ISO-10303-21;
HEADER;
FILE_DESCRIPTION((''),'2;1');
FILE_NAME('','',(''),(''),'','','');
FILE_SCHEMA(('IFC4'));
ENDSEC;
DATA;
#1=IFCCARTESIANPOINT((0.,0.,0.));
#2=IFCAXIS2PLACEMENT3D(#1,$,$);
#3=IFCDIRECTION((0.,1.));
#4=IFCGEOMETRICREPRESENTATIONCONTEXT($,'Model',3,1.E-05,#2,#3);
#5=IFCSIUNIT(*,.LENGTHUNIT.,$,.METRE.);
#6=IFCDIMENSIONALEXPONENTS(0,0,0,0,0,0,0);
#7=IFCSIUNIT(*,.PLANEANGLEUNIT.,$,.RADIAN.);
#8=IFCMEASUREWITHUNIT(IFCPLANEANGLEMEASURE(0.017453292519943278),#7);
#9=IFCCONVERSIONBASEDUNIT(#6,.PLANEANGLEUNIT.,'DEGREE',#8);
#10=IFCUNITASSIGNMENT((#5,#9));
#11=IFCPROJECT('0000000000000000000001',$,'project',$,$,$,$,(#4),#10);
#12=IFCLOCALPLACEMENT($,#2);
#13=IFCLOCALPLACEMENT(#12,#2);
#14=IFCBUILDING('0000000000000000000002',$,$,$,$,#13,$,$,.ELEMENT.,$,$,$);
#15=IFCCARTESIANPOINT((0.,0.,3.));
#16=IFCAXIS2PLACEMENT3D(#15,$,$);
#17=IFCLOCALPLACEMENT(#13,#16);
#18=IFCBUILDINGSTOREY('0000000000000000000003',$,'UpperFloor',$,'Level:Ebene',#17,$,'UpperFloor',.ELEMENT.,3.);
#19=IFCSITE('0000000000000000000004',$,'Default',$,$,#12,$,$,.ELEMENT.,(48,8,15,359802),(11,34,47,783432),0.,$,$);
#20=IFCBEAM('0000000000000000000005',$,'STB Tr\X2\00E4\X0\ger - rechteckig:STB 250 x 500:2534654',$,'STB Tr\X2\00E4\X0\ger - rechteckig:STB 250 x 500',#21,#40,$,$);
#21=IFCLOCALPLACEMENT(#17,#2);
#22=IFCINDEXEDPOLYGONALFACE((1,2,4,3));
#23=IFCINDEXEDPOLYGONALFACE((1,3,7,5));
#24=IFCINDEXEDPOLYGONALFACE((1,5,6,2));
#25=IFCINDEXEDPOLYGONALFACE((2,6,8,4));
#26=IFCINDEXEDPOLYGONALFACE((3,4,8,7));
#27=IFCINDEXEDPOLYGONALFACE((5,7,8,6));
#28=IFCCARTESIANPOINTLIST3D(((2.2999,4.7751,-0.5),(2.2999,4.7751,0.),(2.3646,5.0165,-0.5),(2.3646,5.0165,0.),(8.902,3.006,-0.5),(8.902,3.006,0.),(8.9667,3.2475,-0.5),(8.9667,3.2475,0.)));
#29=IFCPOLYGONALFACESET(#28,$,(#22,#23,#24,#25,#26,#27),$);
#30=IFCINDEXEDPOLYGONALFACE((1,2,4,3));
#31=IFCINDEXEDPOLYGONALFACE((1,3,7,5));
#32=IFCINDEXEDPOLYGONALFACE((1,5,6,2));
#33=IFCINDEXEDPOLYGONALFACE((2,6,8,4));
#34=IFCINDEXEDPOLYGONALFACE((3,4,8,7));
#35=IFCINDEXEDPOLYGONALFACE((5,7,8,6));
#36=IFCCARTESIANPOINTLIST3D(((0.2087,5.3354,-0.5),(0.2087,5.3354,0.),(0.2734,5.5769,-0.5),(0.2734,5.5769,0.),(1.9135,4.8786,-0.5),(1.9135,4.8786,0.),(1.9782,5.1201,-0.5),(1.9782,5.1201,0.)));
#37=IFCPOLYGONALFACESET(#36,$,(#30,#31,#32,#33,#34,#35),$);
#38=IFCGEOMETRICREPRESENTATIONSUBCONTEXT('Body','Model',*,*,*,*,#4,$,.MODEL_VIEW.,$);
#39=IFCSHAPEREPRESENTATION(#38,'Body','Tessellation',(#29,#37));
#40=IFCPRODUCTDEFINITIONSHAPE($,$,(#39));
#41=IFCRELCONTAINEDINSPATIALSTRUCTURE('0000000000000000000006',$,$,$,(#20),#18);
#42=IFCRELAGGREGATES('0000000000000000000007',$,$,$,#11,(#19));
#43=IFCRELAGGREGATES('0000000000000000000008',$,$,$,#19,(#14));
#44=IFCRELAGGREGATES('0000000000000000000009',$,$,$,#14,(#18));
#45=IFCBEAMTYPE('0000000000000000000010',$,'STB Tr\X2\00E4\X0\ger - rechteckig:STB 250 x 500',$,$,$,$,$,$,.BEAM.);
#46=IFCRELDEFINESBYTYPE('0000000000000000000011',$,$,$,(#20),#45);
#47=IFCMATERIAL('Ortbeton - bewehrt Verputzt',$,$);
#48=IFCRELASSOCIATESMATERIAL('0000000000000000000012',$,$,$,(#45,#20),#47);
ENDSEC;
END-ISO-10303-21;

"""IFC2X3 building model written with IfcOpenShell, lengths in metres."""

from ifc_helpers import new_model, entity, si_unit, converted_unit, direction, frame, frame_2d, origin, origin_2d_with_axis, place, context, subcontext, project, spatial, rectangle, extrude, source, transform, mapped, material, type_object, type_shapes, element, save


model = new_model("IFC2X3")

# Units and contexts
model_context = context("Model", 3, precision=1e-05, world=origin(), true_north=direction((0.0, 1.0)))
body_context = subcontext(model_context, "Body", "Model", "MODEL_VIEW")
ifc_project = project(units=[si_unit("LENGTHUNIT", "METRE"), converted_unit("PLANEANGLEUNIT", "DEGREE", entity("IfcPlaneAngleMeasure", 0.017453292519943278), si_unit("PLANEANGLEUNIT", "RADIAN"), dimensions=[0, 0, 0, 0, 0, 0, 0])], contexts=[model_context])

# Site, building, storey
site_placement = place(None, origin())
site = spatial("IfcSite", under=ifc_project, at=site_placement, Name="Default", CompositionType="ELEMENT", RefLatitude=(48, 8, 15, 359802), RefLongitude=(11, 34, 47, 783432), RefElevation=0.0)
building_placement = place(site_placement, origin())
building = spatial("IfcBuilding", under=site, at=building_placement, CompositionType="ELEMENT")
storey_placement = place(building_placement, frame((0.0, 0.0, 3.0)))
storey = spatial("IfcBuildingStorey", under=building, at=storey_placement, Name="UpperFloor", ObjectType="Level:Ebene", LongName="UpperFloor", CompositionType="ELEMENT", Elevation=3.0)

# Beam
ifc_material = material(Name="Ortbeton - bewehrt Verputzt")
beam_type = type_object("IfcBeamType", Name="STB Träger - rechteckig:STB 250 x 500", PredefinedType="BEAM", material=ifc_material)
shared_shape = source(origin(), body_context, "Body", "SweptSolid", [
    extrude(rectangle(XDim=0.5, YDim=0.25, at=frame_2d((0.0, 0.0), x_axis=(1.0, 0.0))), frame((2.3322, 4.8958, 2.75), z_axis=(0.965926, -0.258819, 0.0), x_axis=(0.0, 0.0, -1.0)), (0.0, 0.0, 1.0), 6.835),
    extrude(rectangle(XDim=0.5, YDim=0.25, at=origin_2d_with_axis()), frame((0.241, 5.4561, 2.75), z_axis=(0.965926, -0.258819, 0.0), x_axis=(0.0, 0.0, -1.0)), (0.0, 0.0, 1.0), 1.765),
])
type_shapes(beam_type, [shared_shape])
beam_placement = place(storey_placement, frame((0.0, 0.0, -3.0)))
element("IfcBeam", 1, at=beam_placement, inside=storey, type_object=beam_type, material=ifc_material, Name="STB Träger - rechteckig:STB 250 x 500:2534654", ObjectType="STB Träger - rechteckig:STB 250 x 500", context=body_context, shape_type="MappedRepresentation", body=[
    mapped(shared_shape, transform((0.0, 0.0, 0.0), scale=1.0)),
])

save(model, "model.ifc")
